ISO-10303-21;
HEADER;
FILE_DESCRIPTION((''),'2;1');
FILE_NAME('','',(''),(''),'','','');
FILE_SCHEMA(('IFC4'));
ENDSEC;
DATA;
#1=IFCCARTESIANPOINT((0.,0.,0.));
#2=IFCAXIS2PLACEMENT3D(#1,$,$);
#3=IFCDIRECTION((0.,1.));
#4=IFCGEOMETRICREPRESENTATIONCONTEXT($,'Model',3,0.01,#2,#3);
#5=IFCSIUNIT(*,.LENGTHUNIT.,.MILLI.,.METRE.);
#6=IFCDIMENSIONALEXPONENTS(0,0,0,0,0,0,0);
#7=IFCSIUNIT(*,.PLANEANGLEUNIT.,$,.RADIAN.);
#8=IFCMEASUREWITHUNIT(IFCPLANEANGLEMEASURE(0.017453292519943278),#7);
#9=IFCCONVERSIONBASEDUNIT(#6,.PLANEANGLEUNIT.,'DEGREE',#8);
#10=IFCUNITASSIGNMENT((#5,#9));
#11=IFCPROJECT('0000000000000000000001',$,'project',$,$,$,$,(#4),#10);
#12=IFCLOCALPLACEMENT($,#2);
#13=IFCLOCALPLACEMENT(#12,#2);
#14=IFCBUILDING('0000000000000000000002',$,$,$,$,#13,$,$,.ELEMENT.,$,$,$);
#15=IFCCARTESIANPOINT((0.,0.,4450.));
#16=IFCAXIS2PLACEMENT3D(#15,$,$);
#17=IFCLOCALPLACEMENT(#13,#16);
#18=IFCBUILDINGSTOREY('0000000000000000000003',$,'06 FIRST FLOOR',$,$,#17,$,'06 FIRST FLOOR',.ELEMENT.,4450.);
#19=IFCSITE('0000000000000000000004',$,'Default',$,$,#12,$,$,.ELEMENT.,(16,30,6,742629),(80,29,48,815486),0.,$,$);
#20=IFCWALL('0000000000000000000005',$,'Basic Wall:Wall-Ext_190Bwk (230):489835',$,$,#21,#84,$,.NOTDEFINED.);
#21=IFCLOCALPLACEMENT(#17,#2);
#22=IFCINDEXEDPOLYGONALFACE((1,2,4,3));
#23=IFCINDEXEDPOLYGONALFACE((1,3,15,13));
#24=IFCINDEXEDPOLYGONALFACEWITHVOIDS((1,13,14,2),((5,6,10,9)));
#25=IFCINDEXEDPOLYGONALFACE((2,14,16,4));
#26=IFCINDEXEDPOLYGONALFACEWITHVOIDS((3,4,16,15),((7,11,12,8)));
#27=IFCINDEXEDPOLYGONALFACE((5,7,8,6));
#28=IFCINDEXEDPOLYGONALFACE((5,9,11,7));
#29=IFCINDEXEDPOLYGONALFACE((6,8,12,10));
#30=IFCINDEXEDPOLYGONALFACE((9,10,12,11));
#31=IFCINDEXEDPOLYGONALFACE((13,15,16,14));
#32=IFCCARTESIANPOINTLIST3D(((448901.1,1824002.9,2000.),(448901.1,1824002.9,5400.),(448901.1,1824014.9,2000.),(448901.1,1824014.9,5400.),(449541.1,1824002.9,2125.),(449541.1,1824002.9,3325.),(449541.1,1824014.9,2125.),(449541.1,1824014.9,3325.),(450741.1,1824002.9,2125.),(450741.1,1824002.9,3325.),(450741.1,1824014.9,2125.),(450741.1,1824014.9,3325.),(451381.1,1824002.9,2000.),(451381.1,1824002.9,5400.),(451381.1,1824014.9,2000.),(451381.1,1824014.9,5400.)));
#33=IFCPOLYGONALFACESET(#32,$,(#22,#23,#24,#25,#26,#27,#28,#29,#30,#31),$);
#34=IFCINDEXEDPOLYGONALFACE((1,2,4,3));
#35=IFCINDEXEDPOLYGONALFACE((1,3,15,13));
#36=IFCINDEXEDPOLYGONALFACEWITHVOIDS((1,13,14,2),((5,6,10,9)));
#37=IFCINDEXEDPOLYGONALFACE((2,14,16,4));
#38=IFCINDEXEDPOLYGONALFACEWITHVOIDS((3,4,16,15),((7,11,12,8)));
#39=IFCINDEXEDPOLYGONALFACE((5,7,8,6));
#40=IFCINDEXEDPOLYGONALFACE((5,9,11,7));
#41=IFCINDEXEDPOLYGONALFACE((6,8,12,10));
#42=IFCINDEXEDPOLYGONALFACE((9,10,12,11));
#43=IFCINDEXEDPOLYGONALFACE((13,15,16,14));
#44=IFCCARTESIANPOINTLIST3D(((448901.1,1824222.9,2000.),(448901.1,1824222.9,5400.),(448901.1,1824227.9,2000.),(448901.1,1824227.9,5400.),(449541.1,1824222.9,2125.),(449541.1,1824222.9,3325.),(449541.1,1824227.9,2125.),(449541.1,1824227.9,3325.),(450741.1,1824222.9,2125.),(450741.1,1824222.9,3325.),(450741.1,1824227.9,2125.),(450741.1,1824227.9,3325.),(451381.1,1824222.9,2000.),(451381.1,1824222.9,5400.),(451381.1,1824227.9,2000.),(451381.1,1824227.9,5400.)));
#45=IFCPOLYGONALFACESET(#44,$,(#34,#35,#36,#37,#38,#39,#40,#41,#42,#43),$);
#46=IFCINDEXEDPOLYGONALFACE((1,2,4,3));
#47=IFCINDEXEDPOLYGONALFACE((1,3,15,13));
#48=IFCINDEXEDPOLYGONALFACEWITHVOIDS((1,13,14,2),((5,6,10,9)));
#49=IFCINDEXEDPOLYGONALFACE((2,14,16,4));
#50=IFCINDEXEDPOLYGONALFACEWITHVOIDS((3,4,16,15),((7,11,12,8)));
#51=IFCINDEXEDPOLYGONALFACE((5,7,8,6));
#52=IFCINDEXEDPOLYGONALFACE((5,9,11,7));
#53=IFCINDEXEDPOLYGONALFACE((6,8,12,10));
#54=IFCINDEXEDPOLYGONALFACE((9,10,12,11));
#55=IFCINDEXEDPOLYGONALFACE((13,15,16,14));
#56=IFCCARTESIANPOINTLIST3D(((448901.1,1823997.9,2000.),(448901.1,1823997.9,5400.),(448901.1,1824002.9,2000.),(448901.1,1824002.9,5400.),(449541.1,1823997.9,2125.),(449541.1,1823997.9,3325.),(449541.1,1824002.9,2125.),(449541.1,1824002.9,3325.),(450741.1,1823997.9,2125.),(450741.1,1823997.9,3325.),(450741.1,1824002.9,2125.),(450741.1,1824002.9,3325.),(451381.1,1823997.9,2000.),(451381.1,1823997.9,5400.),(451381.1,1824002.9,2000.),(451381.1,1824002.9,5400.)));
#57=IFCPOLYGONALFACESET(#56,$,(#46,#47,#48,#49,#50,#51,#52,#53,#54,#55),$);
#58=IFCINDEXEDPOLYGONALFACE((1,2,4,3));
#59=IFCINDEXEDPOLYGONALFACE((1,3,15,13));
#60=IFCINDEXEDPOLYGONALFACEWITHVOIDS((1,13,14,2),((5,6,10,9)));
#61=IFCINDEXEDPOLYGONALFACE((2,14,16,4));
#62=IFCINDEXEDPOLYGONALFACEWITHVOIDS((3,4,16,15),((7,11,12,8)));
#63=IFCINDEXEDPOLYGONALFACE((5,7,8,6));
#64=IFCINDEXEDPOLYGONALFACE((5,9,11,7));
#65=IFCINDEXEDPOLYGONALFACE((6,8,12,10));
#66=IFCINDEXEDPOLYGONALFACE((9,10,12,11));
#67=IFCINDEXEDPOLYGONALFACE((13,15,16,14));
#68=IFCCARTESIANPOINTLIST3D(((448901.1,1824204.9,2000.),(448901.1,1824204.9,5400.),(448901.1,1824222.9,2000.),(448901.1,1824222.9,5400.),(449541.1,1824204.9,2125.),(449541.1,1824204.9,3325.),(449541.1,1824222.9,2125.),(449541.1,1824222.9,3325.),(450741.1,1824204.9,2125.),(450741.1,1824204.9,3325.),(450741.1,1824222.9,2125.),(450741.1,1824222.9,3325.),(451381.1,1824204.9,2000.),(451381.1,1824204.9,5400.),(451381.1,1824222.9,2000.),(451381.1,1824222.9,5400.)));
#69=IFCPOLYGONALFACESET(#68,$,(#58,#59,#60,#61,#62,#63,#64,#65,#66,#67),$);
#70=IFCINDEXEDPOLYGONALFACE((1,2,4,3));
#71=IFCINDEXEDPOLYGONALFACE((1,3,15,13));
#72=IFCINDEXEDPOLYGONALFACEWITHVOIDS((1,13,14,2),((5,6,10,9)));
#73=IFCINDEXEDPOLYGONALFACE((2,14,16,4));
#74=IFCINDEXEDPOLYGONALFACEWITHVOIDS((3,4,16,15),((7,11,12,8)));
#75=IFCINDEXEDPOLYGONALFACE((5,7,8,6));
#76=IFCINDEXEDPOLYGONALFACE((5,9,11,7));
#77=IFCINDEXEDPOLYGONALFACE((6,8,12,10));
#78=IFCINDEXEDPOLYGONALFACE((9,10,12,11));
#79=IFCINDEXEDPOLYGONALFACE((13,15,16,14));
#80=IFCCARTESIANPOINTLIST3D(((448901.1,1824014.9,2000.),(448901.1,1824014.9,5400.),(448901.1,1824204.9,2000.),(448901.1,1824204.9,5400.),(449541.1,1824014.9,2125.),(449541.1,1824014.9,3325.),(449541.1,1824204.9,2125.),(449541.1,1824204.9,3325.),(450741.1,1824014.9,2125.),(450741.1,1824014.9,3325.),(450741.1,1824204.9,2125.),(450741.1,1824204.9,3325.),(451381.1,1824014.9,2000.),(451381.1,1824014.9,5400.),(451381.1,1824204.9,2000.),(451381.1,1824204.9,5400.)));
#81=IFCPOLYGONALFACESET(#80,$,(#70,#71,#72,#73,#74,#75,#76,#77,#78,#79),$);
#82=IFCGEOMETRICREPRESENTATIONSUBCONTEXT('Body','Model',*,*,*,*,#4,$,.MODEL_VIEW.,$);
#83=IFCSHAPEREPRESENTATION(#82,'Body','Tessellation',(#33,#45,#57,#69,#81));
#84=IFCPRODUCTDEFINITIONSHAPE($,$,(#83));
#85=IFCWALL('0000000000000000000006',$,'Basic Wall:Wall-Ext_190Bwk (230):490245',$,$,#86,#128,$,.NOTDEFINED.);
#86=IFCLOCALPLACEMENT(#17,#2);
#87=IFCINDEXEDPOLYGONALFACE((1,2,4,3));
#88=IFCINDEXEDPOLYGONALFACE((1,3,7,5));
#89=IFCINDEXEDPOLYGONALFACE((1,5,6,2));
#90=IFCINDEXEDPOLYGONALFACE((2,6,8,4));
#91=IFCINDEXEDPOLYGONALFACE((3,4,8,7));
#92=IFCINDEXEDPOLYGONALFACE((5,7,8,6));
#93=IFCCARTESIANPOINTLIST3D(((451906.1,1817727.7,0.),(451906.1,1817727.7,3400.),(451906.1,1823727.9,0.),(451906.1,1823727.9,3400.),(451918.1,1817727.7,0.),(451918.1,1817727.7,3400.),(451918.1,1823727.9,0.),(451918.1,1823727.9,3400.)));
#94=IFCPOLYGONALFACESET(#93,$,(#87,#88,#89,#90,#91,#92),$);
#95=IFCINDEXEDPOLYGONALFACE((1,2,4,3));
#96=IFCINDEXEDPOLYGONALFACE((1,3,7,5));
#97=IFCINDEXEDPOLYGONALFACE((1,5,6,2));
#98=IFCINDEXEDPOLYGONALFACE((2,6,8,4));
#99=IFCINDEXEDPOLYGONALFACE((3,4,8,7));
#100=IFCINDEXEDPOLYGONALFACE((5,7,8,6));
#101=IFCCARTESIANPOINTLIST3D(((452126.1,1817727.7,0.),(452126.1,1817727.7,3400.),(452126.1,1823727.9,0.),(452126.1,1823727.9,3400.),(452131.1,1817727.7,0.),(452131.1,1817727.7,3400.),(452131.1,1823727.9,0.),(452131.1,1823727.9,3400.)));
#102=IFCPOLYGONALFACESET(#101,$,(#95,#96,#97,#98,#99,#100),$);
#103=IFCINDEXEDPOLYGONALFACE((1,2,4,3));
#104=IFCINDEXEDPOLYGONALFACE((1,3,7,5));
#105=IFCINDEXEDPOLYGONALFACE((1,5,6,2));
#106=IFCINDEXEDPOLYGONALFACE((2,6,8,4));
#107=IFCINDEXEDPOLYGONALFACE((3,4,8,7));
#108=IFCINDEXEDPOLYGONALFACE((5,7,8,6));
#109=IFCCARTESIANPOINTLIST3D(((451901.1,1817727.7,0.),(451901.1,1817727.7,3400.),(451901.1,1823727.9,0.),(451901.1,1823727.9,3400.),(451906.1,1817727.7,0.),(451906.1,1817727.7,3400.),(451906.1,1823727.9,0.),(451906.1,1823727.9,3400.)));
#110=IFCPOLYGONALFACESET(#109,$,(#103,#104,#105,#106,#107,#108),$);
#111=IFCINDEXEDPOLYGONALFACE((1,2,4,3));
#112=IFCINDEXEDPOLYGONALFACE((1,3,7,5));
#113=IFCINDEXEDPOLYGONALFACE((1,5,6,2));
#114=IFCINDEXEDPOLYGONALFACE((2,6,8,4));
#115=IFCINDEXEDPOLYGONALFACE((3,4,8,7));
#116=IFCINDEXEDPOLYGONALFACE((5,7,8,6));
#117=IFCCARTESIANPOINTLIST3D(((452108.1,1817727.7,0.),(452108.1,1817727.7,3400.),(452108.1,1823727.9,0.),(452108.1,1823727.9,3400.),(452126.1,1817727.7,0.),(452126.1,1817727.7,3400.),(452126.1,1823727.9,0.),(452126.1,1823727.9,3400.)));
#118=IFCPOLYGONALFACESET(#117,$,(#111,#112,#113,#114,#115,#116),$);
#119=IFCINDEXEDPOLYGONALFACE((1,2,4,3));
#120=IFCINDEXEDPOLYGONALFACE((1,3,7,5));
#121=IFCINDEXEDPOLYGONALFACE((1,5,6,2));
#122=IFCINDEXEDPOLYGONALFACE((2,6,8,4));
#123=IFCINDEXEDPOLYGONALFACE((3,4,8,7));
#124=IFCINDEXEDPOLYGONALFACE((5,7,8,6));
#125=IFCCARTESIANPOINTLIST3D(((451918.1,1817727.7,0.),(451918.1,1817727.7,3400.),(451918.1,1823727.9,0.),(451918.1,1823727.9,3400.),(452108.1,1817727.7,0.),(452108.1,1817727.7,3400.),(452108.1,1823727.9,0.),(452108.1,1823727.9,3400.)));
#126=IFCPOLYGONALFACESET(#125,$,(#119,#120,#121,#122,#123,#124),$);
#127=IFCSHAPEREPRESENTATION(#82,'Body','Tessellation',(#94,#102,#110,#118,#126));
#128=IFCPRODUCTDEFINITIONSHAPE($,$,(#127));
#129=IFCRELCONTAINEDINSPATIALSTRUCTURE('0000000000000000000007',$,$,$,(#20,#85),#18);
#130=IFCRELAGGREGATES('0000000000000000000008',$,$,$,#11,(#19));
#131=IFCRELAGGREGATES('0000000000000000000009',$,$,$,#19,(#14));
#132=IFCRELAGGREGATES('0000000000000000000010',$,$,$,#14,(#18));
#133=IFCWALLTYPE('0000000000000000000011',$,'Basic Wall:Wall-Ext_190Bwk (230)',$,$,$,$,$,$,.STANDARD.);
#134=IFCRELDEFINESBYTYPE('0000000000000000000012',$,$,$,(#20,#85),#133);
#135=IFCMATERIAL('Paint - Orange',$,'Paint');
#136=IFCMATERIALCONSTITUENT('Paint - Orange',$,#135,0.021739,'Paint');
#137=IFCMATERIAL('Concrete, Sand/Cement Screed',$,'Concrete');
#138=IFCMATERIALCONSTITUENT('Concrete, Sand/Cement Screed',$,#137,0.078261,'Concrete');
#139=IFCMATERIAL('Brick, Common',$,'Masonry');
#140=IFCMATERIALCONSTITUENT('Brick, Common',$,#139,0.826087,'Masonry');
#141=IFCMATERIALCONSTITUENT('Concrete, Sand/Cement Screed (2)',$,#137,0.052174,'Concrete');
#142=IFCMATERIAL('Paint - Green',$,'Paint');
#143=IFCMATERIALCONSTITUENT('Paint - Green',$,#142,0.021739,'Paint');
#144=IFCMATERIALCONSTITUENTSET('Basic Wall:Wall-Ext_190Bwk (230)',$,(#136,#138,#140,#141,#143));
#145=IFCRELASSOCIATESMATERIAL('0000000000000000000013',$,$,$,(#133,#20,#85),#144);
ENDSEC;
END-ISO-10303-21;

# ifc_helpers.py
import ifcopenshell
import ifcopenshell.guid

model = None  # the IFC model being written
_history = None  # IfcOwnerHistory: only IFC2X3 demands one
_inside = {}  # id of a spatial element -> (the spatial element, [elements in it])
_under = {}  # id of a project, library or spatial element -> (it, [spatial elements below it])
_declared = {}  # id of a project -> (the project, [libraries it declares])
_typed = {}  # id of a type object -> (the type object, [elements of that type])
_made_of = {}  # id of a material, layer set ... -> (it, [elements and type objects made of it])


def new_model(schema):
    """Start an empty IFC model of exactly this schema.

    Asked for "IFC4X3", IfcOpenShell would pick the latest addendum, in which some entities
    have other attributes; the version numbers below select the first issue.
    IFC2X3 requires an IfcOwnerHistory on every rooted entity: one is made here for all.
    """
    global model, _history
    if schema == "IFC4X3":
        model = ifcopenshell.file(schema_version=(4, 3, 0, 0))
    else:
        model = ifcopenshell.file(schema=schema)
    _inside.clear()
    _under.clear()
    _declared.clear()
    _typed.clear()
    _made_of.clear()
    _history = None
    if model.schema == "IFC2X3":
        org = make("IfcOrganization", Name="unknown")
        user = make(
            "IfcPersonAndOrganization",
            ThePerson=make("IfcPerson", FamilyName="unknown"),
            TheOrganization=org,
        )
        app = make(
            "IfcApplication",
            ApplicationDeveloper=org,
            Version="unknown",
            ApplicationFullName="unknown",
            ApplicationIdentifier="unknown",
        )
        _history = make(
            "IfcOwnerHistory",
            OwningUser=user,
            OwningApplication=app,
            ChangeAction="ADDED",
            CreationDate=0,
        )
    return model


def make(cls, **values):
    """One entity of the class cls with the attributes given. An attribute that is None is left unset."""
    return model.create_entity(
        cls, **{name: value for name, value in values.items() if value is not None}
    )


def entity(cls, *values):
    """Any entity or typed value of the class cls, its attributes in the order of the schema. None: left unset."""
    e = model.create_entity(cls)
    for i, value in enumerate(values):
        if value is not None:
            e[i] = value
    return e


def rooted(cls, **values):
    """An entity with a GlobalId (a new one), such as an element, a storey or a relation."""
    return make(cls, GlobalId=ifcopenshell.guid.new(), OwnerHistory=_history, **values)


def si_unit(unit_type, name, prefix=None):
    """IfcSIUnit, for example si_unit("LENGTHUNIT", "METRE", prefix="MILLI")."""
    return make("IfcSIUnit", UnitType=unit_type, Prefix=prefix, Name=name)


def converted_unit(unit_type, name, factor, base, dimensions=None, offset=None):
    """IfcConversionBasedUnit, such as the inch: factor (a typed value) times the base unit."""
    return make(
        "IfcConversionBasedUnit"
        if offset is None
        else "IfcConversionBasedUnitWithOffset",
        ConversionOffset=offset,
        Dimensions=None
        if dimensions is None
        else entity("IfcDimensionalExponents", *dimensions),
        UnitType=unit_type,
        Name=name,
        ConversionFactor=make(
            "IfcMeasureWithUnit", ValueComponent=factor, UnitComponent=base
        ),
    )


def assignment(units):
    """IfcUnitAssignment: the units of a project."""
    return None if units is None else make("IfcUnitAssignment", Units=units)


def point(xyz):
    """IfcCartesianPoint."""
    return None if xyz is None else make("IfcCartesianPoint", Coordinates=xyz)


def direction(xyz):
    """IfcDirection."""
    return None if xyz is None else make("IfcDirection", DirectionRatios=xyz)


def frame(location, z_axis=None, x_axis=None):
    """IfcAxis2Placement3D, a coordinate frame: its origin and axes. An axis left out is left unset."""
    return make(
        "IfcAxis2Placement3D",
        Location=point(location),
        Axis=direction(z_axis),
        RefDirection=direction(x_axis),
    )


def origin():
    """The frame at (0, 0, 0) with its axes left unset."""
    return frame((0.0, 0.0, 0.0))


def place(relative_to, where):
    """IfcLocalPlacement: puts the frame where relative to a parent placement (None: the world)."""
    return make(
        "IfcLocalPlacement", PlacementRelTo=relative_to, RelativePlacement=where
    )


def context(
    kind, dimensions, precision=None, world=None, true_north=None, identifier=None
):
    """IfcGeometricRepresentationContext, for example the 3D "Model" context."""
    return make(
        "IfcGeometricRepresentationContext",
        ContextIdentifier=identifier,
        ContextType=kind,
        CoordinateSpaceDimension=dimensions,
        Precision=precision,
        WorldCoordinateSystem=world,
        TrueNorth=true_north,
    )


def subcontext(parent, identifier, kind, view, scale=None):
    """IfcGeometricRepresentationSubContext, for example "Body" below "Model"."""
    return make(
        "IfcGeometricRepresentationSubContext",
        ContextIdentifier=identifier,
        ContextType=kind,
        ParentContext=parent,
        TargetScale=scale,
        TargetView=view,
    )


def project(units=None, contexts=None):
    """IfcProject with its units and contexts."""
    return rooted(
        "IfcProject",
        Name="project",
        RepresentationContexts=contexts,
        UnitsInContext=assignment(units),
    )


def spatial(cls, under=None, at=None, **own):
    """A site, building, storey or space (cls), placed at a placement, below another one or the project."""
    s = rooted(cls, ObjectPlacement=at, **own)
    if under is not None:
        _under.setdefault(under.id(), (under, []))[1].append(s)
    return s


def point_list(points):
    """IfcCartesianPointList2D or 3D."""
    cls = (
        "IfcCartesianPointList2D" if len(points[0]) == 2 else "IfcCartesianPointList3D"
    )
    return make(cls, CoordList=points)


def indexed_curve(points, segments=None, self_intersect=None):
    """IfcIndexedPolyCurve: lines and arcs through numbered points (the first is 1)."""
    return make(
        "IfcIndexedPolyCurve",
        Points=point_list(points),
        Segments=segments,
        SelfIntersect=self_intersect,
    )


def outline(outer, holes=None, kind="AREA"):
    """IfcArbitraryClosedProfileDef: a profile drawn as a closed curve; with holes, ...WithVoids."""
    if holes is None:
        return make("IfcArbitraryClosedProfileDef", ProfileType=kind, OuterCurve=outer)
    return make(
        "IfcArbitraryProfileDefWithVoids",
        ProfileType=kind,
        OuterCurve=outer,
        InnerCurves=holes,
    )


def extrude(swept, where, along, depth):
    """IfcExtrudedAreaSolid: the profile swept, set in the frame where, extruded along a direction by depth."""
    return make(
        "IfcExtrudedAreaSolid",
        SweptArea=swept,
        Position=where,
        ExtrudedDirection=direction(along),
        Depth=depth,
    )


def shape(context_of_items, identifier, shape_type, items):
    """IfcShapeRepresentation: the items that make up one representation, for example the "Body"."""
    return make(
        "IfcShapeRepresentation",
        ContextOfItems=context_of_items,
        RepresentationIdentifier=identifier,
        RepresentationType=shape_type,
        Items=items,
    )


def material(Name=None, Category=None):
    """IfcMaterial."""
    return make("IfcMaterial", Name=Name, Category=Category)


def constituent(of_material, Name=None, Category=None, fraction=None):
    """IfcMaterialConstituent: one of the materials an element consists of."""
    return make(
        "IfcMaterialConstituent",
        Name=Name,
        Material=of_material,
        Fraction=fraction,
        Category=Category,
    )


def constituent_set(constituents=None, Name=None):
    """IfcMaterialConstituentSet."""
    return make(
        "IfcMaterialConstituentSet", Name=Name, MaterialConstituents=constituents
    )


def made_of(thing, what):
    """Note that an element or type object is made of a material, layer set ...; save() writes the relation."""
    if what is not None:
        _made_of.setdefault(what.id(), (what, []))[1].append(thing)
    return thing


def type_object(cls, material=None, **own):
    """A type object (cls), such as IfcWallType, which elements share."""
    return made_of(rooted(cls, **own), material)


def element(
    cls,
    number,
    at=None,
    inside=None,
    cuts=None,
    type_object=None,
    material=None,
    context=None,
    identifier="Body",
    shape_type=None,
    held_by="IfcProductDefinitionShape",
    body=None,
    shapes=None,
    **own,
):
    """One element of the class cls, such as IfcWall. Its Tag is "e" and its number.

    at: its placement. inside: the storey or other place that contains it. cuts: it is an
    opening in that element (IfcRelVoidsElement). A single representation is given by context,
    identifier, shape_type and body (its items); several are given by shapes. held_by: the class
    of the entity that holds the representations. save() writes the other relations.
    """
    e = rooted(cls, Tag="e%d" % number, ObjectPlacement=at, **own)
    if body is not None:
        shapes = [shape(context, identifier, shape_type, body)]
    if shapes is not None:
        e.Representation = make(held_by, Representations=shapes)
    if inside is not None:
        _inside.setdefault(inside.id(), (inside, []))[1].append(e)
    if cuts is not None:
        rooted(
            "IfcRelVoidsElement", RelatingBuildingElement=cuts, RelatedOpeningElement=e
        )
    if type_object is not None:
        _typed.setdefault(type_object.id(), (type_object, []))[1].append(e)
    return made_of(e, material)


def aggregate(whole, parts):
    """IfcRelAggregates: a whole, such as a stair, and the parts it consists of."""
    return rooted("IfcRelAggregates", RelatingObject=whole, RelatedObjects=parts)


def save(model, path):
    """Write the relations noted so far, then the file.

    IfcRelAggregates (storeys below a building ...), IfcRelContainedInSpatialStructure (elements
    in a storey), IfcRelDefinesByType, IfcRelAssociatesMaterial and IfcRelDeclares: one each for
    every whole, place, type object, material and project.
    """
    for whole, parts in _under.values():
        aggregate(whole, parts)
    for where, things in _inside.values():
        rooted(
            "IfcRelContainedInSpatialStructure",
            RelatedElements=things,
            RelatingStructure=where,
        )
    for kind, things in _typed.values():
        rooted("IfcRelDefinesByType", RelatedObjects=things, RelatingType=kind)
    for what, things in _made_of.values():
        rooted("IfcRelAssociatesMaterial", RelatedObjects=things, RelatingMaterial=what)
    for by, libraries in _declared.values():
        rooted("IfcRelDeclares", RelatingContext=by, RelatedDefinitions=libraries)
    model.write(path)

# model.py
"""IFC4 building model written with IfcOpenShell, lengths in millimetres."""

from ifc_helpers import new_model, entity, si_unit, converted_unit, direction, frame, origin, place, context, subcontext, project, spatial, indexed_curve, outline, extrude, material, constituent, constituent_set, type_object, element, save


model = new_model("IFC4")

# Units and contexts
model_context = context("Model", 3, precision=0.01, world=origin(), true_north=direction((0.0, 1.0)))
body_context = subcontext(model_context, "Body", "Model", "MODEL_VIEW")
ifc_project = project(units=[si_unit("LENGTHUNIT", "METRE", prefix="MILLI"), converted_unit("PLANEANGLEUNIT", "DEGREE", entity("IfcPlaneAngleMeasure", 0.017453292519943278), si_unit("PLANEANGLEUNIT", "RADIAN"), dimensions=[0, 0, 0, 0, 0, 0, 0])], contexts=[model_context])

# Site, building, storey
site_placement = place(None, origin())
site = spatial("IfcSite", under=ifc_project, at=site_placement, Name="Default", CompositionType="ELEMENT", RefLatitude=(16, 30, 6, 742629), RefLongitude=(80, 29, 48, 815486), RefElevation=0.0)
building_placement = place(site_placement, origin())
building = spatial("IfcBuilding", under=site, at=building_placement, CompositionType="ELEMENT")
storey_placement = place(building_placement, frame((0.0, 0.0, 4450.0)))
storey = spatial("IfcBuildingStorey", under=building, at=storey_placement, Name="06 FIRST FLOOR", LongName="06 FIRST FLOOR", CompositionType="ELEMENT", Elevation=4450.0)

# Shared definitions
ifc_material_1 = material(Name="Concrete, Sand/Cement Screed", Category="Concrete")
ifc_material_2 = material(Name="Brick, Common", Category="Masonry")

# Wall, opening
ifc_material_3 = material(Name="Paint - Orange", Category="Paint")
ifc_constituent_1 = constituent(ifc_material_3, Name="Paint - Orange", Category="Paint", fraction=0.021739)
ifc_constituent_2 = constituent(ifc_material_1, Name="Concrete, Sand/Cement Screed", Category="Concrete", fraction=0.078261)
ifc_constituent_3 = constituent(ifc_material_2, Name="Brick, Common", Category="Masonry", fraction=0.826087)
ifc_constituent_4 = constituent(ifc_material_1, Name="Concrete, Sand/Cement Screed (2)", Category="Concrete", fraction=0.052174)
ifc_material_4 = material(Name="Paint - Green", Category="Paint")
ifc_constituent_5 = constituent(ifc_material_4, Name="Paint - Green", Category="Paint", fraction=0.021739)
ifc_constituent_set_1 = constituent_set(constituents=[ifc_constituent_1, ifc_constituent_2, ifc_constituent_3, ifc_constituent_4, ifc_constituent_5], Name="Basic Wall:Wall-Ext_190Bwk (230)")
wall_type_1 = type_object("IfcWallType", Name="Basic Wall:Wall-Ext_190Bwk (230)", PredefinedType="STANDARD", material=ifc_constituent_set_1)
wall_1_placement = place(storey_placement, frame((448901.1, 1824112.9, 2000.0)))
wall_1 = element("IfcWall", 1, at=wall_1_placement, inside=storey, type_object=wall_type_1, material=ifc_constituent_set_1, Name="Basic Wall:Wall-Ext_190Bwk (230):489835", PredefinedType="NOTDEFINED", context=body_context, shape_type="SweptSolid", body=[
    extrude(outline(indexed_curve([(-1700.0, -1240.0), (1700.0, -1240.0), (1700.0, 1240.0), (-1700.0, 1240.0), (-1700.0, -1240.0)], self_intersect=False), holes=[indexed_curve([(-1575.0, -600.0), (-1575.0, 600.0), (-375.0, 600.0), (-375.0, -600.0), (-1575.0, -600.0)], self_intersect=False)]), frame((1240.0, -110.0, 1700.0), z_axis=(0.0, 1.0, 0.0), x_axis=(0.0, 0.0, 1.0)), (0.0, 0.0, 1.0), 12.0),
    extrude(outline(indexed_curve([(-1700.0, -1240.0), (1700.0, -1240.0), (1700.0, 1240.0), (-1700.0, 1240.0), (-1700.0, -1240.0)], self_intersect=False), holes=[indexed_curve([(-1575.0, -600.0), (-1575.0, 600.0), (-375.0, 600.0), (-375.0, -600.0), (-1575.0, -600.0)], self_intersect=False)]), frame((1240.0, 110.0, 1700.0), z_axis=(0.0, 1.0, 0.0), x_axis=(0.0, 0.0, 1.0)), (0.0, 0.0, 1.0), 5.0),
    extrude(outline(indexed_curve([(-1700.0, -1240.0), (1700.0, -1240.0), (1700.0, 1240.0), (-1700.0, 1240.0), (-1700.0, -1240.0)], self_intersect=False), holes=[indexed_curve([(-375.0, -600.0), (-1575.0, -600.0), (-1575.0, 600.0), (-375.0, 600.0), (-375.0, -600.0)], self_intersect=False)]), frame((1240.0, -115.0, 1700.0), z_axis=(0.0, 1.0, 0.0), x_axis=(0.0, 0.0, 1.0)), (0.0, 0.0, 1.0), 5.0),
    extrude(outline(indexed_curve([(-1700.0, -1240.0), (1700.0, -1240.0), (1700.0, 1240.0), (-1700.0, 1240.0), (-1700.0, -1240.0)], self_intersect=False), holes=[indexed_curve([(-1575.0, -600.0), (-1575.0, 600.0), (-375.0, 600.0), (-375.0, -600.0), (-1575.0, -600.0)], self_intersect=False)]), frame((1240.0, 92.0, 1700.0), z_axis=(0.0, 1.0, 0.0), x_axis=(0.0, 0.0, 1.0)), (0.0, 0.0, 1.0), 18.0),
    extrude(outline(indexed_curve([(-1700.0, -1240.0), (1700.0, -1240.0), (1700.0, 1240.0), (-1700.0, 1240.0), (-1700.0, -1240.0)], self_intersect=False), holes=[indexed_curve([(-1575.0, -600.0), (-1575.0, 600.0), (-375.0, 600.0), (-375.0, -600.0), (-1575.0, -600.0)], self_intersect=False)]), frame((1240.0, -98.0, 1700.0), z_axis=(0.0, 1.0, 0.0), x_axis=(0.0, 0.0, 1.0)), (0.0, 0.0, 1.0), 190.0),
])
opening_1_placement = place(wall_1_placement, frame((1840.0, 115.0, 125.0)))
element("IfcOpeningElement", 2, at=opening_1_placement, cuts=wall_1, PredefinedType="OPENING", context=body_context, shape_type="SweptSolid", body=[
    extrude(outline(indexed_curve([(1200.0, 1200.0), (0.0, 1200.0), (0.0, 0.0), (1200.0, 0.0), (1200.0, 1200.0)], self_intersect=False)), frame((0.0, 0.0, 0.0), z_axis=(0.0, -1.0, 0.0), x_axis=(0.0, 0.0, 1.0)), (0.0, 0.0, 1.0), 230.0),
])

# Wall
wall_2_placement = place(storey_placement, frame((452016.1, 1823727.9, 0.0), z_axis=(0.0, 0.0, 1.0), x_axis=(0.0, -1.0, 0.0)))
element("IfcWall", 3, at=wall_2_placement, inside=storey, type_object=wall_type_1, material=ifc_constituent_set_1, Name="Basic Wall:Wall-Ext_190Bwk (230):490245", PredefinedType="NOTDEFINED", context=body_context, shape_type="SweptSolid", body=[
    extrude(outline(indexed_curve([(-3000.1, -6.0), (3000.1, -6.0), (3000.1, 6.0), (-3000.1, 6.0), (-3000.1, -6.0)], self_intersect=False)), frame((3000.1, -104.0, 0.0)), (0.0, 0.0, 1.0), 3400.0),
    extrude(outline(indexed_curve([(-2.5, -3000.1), (2.5, -3000.1), (2.5, 3000.1), (-2.5, 3000.1), (-2.5, -3000.1)], self_intersect=False)), frame((3000.1, 112.5, 0.0), z_axis=(0.0, 0.0, 1.0), x_axis=(0.0, -1.0, 0.0)), (0.0, 0.0, 1.0), 3400.0),
    extrude(outline(indexed_curve([(-2.5, -3000.1), (2.5, -3000.1), (2.5, 3000.1), (-2.5, 3000.1), (-2.5, -3000.1)], self_intersect=False)), frame((3000.1, -112.5, 0.0), z_axis=(0.0, 0.0, 1.0), x_axis=(0.0, 1.0, 0.0)), (0.0, 0.0, 1.0), 3400.0),
    extrude(outline(indexed_curve([(-3000.1, -9.0), (3000.1, -9.0), (3000.1, 9.0), (-3000.1, 9.0), (-3000.1, -9.0)], self_intersect=False)), frame((3000.1, 101.0, 0.0)), (0.0, 0.0, 1.0), 3400.0),
    extrude(outline(indexed_curve([(-3000.1, -95.0), (3000.1, -95.0), (3000.1, 95.0), (-3000.1, 95.0), (-3000.1, -95.0)], self_intersect=False)), frame((3000.1, -3.0, 0.0)), (0.0, 0.0, 1.0), 3400.0),
])

save(model, "model.ifc")
